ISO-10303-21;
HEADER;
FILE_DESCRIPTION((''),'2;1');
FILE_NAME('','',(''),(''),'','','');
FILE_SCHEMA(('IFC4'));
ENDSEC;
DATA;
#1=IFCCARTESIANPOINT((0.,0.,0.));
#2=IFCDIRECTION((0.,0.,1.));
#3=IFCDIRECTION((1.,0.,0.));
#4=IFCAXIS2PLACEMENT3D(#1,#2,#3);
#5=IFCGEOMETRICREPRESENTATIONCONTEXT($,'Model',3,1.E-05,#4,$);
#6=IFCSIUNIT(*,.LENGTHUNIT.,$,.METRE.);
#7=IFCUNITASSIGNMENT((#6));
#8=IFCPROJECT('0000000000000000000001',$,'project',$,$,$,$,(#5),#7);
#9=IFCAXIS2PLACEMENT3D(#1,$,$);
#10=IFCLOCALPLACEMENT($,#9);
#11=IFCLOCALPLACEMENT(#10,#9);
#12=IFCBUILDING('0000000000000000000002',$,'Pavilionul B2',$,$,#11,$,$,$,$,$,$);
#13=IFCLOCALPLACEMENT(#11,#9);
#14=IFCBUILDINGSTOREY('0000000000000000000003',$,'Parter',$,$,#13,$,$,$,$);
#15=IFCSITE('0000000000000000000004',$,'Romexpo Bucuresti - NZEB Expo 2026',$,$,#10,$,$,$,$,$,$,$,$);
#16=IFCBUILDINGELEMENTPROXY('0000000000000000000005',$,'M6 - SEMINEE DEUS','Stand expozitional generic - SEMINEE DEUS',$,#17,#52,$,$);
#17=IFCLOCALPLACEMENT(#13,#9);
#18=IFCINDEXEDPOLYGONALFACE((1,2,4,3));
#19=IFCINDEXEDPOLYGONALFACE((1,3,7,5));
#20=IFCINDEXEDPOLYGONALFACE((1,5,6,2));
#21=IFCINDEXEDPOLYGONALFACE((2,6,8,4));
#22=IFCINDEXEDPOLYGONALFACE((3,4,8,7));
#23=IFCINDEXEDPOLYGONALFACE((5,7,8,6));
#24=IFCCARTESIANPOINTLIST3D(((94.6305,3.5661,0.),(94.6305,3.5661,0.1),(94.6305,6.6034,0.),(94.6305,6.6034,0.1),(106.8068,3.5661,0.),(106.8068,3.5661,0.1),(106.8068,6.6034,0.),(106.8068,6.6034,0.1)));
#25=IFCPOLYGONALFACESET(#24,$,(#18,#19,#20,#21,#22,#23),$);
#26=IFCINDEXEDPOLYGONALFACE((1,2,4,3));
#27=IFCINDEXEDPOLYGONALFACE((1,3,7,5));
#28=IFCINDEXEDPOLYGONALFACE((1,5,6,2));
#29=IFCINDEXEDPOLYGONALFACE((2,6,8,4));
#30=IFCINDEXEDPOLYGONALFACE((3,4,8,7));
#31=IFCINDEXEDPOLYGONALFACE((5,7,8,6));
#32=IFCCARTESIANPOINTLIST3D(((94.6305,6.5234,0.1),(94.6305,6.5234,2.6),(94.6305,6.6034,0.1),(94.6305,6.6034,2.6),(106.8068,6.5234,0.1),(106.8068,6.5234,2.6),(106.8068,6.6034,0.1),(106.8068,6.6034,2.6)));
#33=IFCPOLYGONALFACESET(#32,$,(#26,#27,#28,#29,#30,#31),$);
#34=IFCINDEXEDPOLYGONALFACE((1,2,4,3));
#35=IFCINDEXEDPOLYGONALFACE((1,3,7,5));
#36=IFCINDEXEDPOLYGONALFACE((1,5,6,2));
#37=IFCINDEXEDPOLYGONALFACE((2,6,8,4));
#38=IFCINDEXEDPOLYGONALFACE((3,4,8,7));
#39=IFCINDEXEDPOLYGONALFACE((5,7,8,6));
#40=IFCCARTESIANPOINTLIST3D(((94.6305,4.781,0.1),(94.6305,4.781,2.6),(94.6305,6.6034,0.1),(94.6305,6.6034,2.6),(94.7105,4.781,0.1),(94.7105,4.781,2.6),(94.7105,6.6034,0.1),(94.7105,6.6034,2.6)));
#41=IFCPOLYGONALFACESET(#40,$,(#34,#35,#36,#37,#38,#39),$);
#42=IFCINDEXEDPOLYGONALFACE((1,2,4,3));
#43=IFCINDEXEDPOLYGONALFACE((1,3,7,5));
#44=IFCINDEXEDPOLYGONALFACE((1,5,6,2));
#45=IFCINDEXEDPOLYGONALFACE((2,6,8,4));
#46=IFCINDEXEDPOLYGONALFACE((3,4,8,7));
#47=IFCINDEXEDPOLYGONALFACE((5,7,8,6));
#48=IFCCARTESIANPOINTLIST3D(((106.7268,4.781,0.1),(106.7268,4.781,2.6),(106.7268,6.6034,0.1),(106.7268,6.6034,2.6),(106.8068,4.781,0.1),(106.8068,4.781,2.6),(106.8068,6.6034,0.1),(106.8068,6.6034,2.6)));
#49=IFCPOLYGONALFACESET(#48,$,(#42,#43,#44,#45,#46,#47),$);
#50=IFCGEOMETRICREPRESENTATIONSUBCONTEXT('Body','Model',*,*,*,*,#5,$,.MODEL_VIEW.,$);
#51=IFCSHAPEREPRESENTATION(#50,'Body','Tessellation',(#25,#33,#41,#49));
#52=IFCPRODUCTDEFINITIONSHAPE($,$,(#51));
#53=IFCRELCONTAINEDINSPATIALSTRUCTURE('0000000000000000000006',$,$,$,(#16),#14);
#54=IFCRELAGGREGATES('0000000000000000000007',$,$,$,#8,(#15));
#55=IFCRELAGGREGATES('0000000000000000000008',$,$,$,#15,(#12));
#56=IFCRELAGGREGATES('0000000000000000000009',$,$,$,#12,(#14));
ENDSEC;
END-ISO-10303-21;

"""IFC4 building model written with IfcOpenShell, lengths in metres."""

from ifc_helpers import new_model, si_unit, frame, frame_2d, origin, origin_with_axes, place, context, subcontext, project, spatial, rectangle, extrude, element, save


model = new_model("IFC4")

# Units and contexts
model_context = context("Model", 3, precision=1e-05, world=origin_with_axes())
body_context = subcontext(model_context, "Body", "Model", "MODEL_VIEW")
ifc_project = project(units=[si_unit("LENGTHUNIT", "METRE")], contexts=[model_context])

# Site, building, storey
site_placement = place(None, origin())
site = spatial("IfcSite", under=ifc_project, at=site_placement, Name="Romexpo Bucuresti - NZEB Expo 2026")
building_placement = place(site_placement, origin())
building = spatial("IfcBuilding", under=site, at=building_placement, Name="Pavilionul B2")
storey_placement = place(building_placement, origin())
storey = spatial("IfcBuildingStorey", under=building, at=storey_placement, Name="Parter")

# Building element proxy
proxy_1_placement = place(storey_placement, frame((94.6305, 3.5661, 0.0), z_axis=(0.0, 0.0, 1.0), x_axis=(1.0, 0.0, 0.0)))
element("IfcBuildingElementProxy", 1, at=proxy_1_placement, inside=storey, Name="M6 - SEMINEE DEUS", Description="Stand expozitional generic - SEMINEE DEUS", context=body_context, shape_type="SweptSolid", body=[
    extrude(rectangle(XDim=12.1763, YDim=3.0373, at=frame_2d((6.0881, 1.5186))), origin(), (0.0, 0.0, 1.0), 0.1),
    extrude(rectangle(XDim=12.1763, YDim=0.08, at=frame_2d((6.0881, 2.9973))), frame((0.0, 0.0, 0.1)), (0.0, 0.0, 1.0), 2.5),
    extrude(rectangle(XDim=0.08, YDim=1.8224, at=frame_2d((0.04, 2.1261))), frame((0.0, 0.0, 0.1)), (0.0, 0.0, 1.0), 2.5),
    extrude(rectangle(XDim=0.08, YDim=1.8224, at=frame_2d((12.1363, 2.1261))), frame((0.0, 0.0, 0.1)), (0.0, 0.0, 1.0), 2.5),
])

save(model, "model.ifc")
